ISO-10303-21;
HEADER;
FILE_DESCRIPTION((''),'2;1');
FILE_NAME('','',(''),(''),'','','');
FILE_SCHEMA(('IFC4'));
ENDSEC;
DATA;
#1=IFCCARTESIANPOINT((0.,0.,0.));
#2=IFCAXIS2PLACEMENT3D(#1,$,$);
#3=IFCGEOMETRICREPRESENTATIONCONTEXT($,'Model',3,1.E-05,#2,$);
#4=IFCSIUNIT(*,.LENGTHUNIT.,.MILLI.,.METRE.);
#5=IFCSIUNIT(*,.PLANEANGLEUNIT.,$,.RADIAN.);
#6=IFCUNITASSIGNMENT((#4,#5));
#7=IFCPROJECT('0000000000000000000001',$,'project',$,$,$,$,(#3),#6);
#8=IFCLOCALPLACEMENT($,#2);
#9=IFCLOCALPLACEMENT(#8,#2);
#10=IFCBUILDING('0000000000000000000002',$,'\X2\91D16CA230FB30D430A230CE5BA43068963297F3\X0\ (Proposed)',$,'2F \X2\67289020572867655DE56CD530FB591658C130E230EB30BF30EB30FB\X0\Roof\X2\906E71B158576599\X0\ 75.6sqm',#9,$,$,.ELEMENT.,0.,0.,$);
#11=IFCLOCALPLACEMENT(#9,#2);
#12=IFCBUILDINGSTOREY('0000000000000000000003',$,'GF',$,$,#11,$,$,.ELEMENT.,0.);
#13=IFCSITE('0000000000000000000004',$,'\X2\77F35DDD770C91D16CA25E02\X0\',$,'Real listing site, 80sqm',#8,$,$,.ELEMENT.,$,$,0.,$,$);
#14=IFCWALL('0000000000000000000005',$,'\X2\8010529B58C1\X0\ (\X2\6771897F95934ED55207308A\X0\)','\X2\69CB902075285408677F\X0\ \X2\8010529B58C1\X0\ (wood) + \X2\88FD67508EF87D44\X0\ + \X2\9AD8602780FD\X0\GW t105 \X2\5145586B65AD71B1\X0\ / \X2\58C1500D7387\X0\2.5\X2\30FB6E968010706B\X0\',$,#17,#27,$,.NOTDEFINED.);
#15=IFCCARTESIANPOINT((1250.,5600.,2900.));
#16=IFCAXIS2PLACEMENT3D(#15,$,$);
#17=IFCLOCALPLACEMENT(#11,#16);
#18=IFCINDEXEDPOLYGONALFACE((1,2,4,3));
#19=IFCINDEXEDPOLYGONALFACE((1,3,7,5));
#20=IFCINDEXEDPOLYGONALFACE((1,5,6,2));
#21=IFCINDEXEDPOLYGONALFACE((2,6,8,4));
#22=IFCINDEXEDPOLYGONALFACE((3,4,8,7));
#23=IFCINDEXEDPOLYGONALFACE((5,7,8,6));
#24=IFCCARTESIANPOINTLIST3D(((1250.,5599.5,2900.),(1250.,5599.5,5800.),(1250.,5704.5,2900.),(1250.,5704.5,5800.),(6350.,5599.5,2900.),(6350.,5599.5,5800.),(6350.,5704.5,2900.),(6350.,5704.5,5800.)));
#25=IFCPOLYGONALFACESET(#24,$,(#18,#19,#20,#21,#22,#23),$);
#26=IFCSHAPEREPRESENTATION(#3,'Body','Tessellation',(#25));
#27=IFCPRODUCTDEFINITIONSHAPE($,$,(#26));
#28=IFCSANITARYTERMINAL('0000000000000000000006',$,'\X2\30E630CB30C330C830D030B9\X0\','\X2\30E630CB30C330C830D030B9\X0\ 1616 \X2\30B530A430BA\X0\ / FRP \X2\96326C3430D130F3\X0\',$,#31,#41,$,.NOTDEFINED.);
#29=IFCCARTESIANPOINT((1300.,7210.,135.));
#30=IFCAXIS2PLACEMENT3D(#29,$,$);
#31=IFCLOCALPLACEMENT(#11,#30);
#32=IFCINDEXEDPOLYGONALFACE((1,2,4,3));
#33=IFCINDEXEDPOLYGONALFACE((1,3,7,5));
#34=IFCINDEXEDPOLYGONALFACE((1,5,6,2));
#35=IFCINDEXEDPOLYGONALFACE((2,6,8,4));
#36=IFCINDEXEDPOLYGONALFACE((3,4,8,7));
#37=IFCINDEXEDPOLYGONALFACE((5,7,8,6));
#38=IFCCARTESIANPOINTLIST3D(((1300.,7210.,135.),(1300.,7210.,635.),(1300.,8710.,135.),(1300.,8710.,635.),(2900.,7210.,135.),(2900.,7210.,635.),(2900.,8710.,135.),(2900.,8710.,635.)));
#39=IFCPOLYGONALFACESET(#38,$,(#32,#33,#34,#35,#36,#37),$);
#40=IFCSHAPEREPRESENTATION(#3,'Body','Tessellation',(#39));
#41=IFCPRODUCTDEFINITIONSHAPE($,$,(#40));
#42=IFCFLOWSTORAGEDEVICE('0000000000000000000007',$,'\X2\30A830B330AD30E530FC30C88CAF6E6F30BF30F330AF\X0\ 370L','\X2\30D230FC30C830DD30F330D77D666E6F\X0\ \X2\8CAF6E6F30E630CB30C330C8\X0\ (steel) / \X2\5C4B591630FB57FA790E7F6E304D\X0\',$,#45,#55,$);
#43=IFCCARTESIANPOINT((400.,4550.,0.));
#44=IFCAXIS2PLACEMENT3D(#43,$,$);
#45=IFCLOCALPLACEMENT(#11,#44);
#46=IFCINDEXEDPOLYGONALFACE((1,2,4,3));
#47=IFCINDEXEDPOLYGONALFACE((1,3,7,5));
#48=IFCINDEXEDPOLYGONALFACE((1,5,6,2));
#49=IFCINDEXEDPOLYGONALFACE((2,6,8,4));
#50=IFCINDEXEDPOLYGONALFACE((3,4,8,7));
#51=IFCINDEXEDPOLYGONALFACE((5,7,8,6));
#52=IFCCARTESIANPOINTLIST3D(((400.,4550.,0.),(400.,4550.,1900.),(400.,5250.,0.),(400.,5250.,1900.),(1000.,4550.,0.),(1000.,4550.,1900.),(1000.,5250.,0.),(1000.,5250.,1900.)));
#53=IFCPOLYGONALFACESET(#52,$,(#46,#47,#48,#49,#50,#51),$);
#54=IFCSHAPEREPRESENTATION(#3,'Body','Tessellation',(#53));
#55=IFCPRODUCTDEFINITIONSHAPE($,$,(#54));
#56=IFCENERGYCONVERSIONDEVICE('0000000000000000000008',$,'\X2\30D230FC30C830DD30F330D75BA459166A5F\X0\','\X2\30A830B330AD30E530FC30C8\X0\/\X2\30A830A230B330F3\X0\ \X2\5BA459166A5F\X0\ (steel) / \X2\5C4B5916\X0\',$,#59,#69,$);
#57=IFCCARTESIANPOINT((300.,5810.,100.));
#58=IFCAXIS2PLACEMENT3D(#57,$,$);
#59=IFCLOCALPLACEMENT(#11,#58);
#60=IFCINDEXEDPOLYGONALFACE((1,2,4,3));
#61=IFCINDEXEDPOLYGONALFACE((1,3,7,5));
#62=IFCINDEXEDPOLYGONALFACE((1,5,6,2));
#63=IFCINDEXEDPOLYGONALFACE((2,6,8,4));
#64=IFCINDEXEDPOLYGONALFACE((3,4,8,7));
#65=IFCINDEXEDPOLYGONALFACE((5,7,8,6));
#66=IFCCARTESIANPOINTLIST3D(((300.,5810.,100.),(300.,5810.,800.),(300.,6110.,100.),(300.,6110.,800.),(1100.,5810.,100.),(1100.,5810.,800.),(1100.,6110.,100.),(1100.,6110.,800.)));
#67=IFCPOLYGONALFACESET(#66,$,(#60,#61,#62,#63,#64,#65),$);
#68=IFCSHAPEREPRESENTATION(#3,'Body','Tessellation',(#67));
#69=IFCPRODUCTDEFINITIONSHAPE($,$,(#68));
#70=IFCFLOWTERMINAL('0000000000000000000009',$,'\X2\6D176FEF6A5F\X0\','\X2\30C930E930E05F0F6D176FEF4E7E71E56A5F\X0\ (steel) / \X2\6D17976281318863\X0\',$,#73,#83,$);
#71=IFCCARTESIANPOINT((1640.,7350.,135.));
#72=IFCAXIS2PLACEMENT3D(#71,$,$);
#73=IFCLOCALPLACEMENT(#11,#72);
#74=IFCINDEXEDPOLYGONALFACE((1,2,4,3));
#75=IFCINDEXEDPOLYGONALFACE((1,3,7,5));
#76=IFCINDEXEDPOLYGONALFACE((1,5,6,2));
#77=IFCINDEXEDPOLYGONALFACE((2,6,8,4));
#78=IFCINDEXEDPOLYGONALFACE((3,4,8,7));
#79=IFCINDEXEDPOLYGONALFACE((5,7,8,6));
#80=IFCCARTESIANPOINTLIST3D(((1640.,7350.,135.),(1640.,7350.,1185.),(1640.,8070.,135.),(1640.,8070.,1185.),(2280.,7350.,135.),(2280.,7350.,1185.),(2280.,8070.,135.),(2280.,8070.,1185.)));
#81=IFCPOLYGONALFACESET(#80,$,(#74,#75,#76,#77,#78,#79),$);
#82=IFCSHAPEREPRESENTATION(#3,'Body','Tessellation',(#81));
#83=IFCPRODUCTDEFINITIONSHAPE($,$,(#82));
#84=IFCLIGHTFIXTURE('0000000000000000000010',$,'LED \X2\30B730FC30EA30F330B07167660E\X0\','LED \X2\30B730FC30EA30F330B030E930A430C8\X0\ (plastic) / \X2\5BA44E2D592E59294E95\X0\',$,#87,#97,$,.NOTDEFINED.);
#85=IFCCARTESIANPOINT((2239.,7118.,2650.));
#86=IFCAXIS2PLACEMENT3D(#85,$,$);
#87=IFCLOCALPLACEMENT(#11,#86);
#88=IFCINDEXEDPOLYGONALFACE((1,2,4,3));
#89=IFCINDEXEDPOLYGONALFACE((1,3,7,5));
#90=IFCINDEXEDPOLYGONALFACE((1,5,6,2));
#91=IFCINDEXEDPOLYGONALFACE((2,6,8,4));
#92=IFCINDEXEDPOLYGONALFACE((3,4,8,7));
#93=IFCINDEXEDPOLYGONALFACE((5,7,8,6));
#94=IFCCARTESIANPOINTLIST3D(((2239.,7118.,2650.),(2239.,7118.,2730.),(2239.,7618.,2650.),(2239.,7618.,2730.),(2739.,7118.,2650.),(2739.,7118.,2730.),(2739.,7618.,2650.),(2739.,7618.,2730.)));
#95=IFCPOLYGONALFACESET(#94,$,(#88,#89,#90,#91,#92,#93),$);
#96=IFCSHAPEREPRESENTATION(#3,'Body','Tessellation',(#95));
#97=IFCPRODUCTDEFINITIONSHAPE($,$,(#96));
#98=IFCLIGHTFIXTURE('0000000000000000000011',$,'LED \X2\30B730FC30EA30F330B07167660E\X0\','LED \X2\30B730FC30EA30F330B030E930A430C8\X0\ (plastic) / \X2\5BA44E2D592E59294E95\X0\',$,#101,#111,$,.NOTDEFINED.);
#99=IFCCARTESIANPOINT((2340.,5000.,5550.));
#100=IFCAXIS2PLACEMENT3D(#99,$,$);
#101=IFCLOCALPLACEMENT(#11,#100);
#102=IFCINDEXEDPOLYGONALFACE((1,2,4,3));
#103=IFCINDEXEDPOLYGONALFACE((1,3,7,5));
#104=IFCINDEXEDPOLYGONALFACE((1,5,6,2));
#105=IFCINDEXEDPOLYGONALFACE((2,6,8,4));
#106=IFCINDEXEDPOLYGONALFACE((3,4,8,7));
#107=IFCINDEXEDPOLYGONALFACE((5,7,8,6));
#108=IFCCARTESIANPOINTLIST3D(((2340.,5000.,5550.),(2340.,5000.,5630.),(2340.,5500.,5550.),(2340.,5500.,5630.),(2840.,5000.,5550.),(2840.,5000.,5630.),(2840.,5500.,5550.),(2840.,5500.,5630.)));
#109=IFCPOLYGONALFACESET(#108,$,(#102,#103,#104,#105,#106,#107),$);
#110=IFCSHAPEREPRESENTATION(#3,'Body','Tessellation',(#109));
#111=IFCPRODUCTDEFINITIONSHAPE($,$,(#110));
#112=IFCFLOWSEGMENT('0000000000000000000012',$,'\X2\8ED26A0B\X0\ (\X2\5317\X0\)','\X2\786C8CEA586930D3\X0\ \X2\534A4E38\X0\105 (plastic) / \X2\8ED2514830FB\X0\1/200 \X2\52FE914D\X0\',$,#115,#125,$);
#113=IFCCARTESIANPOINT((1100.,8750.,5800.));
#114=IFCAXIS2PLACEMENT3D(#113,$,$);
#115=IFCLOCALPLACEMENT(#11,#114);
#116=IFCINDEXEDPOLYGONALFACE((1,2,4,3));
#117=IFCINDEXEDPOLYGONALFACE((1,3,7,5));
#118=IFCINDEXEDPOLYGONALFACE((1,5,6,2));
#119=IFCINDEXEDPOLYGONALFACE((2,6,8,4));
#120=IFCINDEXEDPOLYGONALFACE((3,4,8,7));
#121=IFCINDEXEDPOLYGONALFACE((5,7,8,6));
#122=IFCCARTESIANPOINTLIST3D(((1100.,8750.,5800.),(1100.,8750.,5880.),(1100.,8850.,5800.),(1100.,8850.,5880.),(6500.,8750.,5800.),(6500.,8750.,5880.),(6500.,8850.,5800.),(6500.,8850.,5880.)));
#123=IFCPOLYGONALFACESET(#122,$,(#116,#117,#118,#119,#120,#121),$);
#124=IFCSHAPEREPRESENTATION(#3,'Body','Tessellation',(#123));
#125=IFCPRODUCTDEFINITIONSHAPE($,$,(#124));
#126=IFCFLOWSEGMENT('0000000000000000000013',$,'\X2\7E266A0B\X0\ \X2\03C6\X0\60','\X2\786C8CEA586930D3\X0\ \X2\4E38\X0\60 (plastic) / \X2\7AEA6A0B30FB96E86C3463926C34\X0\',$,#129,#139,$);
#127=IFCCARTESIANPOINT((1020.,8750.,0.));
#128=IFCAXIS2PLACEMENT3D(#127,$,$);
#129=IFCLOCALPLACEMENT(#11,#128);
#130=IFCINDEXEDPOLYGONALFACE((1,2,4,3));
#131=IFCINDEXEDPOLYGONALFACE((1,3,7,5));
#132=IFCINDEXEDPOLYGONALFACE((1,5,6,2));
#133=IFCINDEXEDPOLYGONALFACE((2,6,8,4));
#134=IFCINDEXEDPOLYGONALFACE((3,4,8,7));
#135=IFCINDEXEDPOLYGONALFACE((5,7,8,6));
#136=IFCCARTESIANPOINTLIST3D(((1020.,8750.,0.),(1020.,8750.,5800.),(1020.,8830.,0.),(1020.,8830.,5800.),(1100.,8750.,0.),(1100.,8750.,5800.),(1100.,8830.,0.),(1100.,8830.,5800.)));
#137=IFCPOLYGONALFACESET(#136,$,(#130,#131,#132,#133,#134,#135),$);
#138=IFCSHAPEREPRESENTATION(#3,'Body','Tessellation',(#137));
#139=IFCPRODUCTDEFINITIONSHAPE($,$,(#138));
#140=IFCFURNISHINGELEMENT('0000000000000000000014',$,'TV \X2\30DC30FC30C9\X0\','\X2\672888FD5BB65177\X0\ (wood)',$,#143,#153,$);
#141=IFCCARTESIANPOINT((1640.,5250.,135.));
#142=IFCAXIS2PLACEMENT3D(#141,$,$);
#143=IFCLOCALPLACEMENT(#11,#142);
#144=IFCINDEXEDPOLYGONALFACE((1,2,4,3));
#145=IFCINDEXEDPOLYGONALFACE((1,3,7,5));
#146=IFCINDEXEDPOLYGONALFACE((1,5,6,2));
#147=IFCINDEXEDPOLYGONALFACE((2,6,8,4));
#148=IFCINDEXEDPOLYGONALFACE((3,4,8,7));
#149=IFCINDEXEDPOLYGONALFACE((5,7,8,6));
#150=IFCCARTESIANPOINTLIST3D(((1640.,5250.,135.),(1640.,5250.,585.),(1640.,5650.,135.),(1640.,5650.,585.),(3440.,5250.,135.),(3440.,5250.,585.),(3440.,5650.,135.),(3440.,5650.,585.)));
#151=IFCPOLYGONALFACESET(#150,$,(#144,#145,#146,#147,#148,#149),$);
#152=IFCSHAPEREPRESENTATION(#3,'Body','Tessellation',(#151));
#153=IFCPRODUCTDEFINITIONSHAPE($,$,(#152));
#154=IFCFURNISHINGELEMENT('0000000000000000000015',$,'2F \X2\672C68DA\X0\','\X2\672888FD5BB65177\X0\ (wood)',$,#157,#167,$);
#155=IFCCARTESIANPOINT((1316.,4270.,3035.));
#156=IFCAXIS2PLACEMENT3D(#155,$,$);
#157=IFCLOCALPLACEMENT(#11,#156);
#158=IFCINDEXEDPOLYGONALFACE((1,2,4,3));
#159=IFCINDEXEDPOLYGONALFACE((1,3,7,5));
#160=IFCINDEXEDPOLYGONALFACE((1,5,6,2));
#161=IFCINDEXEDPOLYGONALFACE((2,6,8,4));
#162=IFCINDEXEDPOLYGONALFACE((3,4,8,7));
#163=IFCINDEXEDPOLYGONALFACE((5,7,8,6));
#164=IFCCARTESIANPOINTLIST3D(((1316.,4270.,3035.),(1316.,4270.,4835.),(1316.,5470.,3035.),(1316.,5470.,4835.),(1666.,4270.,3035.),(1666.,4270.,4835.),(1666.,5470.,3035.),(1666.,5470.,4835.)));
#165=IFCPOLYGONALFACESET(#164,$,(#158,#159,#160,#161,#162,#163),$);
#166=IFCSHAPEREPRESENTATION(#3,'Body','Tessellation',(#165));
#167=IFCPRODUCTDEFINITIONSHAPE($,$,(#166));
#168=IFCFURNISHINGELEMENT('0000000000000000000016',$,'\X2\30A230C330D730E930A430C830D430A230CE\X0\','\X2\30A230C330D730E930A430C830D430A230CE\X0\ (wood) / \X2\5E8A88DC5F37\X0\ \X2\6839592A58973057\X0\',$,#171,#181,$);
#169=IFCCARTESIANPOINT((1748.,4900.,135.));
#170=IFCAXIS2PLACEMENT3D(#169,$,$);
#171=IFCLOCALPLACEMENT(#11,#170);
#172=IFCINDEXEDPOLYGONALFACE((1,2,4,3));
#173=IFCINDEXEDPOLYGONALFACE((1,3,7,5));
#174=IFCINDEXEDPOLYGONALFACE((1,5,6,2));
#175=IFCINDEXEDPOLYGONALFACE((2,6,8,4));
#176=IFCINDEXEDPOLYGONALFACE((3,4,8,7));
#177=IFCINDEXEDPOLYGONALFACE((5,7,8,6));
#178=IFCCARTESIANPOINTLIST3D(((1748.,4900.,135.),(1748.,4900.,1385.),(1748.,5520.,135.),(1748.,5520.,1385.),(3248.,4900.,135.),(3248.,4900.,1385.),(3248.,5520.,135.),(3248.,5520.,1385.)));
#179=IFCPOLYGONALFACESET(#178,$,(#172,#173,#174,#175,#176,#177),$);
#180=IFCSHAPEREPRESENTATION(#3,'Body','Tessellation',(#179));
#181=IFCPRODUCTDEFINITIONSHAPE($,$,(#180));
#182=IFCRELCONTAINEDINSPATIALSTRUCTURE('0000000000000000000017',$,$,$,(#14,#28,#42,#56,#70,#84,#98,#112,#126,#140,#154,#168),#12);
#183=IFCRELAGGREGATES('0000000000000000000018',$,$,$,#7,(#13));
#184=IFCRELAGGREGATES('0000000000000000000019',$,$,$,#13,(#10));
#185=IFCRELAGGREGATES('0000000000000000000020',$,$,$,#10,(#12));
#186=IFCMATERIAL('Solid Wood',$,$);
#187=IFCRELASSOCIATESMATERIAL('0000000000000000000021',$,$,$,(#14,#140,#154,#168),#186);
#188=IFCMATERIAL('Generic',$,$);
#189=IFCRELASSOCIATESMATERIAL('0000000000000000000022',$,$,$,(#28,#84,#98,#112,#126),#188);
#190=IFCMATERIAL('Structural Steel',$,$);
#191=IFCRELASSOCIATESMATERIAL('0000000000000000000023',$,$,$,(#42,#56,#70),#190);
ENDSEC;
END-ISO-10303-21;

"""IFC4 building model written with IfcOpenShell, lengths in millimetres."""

from ifc_helpers import new_model, si_unit, frame, frame_2d, origin, place, context, project, spatial, rectangle, extrude, material, element, save


model = new_model("IFC4")

# Units and contexts
model_context = context("Model", 3, precision=1e-05, world=origin())
ifc_project = project(units=[si_unit("LENGTHUNIT", "METRE", prefix="MILLI"), si_unit("PLANEANGLEUNIT", "RADIAN")], contexts=[model_context])

# Site, building, storey
site_placement = place(None, origin())
site = spatial("IfcSite", under=ifc_project, at=site_placement, Name="石川県金沢市", ObjectType="Real listing site, 80sqm", CompositionType="ELEMENT", RefElevation=0.0)
building_placement = place(site_placement, origin())
building = spatial("IfcBuilding", under=site, at=building_placement, Name="金沢・ピアノ室と防音 (Proposed)", ObjectType="2F 木造在来工法・外壁モルタル・Roof遮熱塗料 75.6sqm", CompositionType="ELEMENT", ElevationOfRefHeight=0.0, ElevationOfTerrain=0.0)
storey_placement = place(building_placement, origin())
storey = spatial("IfcBuildingStorey", under=building, at=storey_placement, Name="GF", CompositionType="ELEMENT", Elevation=0.0)

# Shared definitions
ifc_material_1 = material(Name="Solid Wood")

# Wall
wall_1_placement = place(storey_placement, frame((1250.0, 5600.0, 2900.0)))
element("IfcWall", 1, at=wall_1_placement, inside=storey, material=ifc_material_1, Name="耐力壁 (東西間仕切り)", Description="構造用合板 耐力壁 (wood) + 製材軸組 + 高性能GW t105 充填断熱 / 壁倍率2.5・準耐火", PredefinedType="NOTDEFINED", context=model_context, shape_type="SweptSolid", body=[
    extrude(rectangle(XDim=5100.0, YDim=105.0, at=frame_2d((2550.0, 52.0))), frame((1250.0, 5600.0, 2900.0)), (0.0, 0.0, 1.0), 2900.0),
])

# Sanitary terminal
ifc_material_2 = material(Name="Generic")
sanitary_terminal_placement = place(storey_placement, frame((1300.0, 7210.0, 135.0)))
element("IfcSanitaryTerminal", 2, at=sanitary_terminal_placement, inside=storey, material=ifc_material_2, Name="ユニットバス", Description="ユニットバス 1616 サイズ / FRP 防水パン", PredefinedType="NOTDEFINED", context=model_context, shape_type="SweptSolid", body=[
    extrude(rectangle(XDim=1600.0, YDim=1500.0, at=frame_2d((800.0, 750.0))), frame((1300.0, 7210.0, 135.0)), (0.0, 0.0, 1.0), 500.0),
])

# Flow storage device
ifc_material_3 = material(Name="Structural Steel")
flow_storage_device_placement = place(storey_placement, frame((400.0, 4550.0, 0.0)))
element("IfcFlowStorageDevice", 3, at=flow_storage_device_placement, inside=storey, material=ifc_material_3, Name="エコキュート貯湯タンク 370L", Description="ヒートポンプ給湯 貯湯ユニット (steel) / 屋外・基礎置き", context=model_context, shape_type="SweptSolid", body=[
    extrude(rectangle(XDim=600.0, YDim=700.0, at=frame_2d((300.0, 350.0))), frame((400.0, 4550.0, 0.0)), (0.0, 0.0, 1.0), 1900.0),
])

# Energy conversion device
energy_conversion_device_placement = place(storey_placement, frame((300.0, 5810.0, 100.0)))
element("IfcEnergyConversionDevice", 4, at=energy_conversion_device_placement, inside=storey, material=ifc_material_3, Name="ヒートポンプ室外機", Description="エコキュート/エアコン 室外機 (steel) / 屋外", context=model_context, shape_type="SweptSolid", body=[
    extrude(rectangle(XDim=800.0, YDim=300.0, at=frame_2d((400.0, 150.0))), frame((300.0, 5810.0, 100.0)), (0.0, 0.0, 1.0), 700.0),
])

# Flow terminal
flow_terminal_placement = place(storey_placement, frame((1640.0, 7350.0, 135.0)))
element("IfcFlowTerminal", 5, at=flow_terminal_placement, inside=storey, material=ifc_material_3, Name="洗濯機", Description="ドラム式洗濯乾燥機 (steel) / 洗面脱衣", context=model_context, shape_type="SweptSolid", body=[
    extrude(rectangle(XDim=640.0, YDim=720.0, at=frame_2d((320.0, 360.0))), frame((1640.0, 7350.0, 135.0)), (0.0, 0.0, 1.0), 1050.0),
])

# Light fixtures
light_fixture_1_placement = place(storey_placement, frame((2239.0, 7118.0, 2650.0)))
element("IfcLightFixture", 6, at=light_fixture_1_placement, inside=storey, material=ifc_material_2, Name="LED シーリング照明", Description="LED シーリングライト (plastic) / 室中央天井", PredefinedType="NOTDEFINED", context=model_context, shape_type="SweptSolid", body=[
    extrude(rectangle(XDim=500.0, YDim=500.0, at=frame_2d((250.0, 250.0))), frame((2239.0, 7118.0, 2650.0)), (0.0, 0.0, 1.0), 80.0),
])
light_fixture_2_placement = place(storey_placement, frame((2340.0, 5000.0, 5550.0)))
element("IfcLightFixture", 7, at=light_fixture_2_placement, inside=storey, material=ifc_material_2, Name="LED シーリング照明", Description="LED シーリングライト (plastic) / 室中央天井", PredefinedType="NOTDEFINED", context=model_context, shape_type="SweptSolid", body=[
    extrude(rectangle(XDim=500.0, YDim=500.0, at=frame_2d((250.0, 250.0))), frame((2340.0, 5000.0, 5550.0)), (0.0, 0.0, 1.0), 80.0),
])

# Flow segments
flow_segment_1_placement = place(storey_placement, frame((1100.0, 8750.0, 5800.0)))
element("IfcFlowSegment", 8, at=flow_segment_1_placement, inside=storey, material=ifc_material_2, Name="軒樋 (北)", Description="硬質塩ビ 半丸105 (plastic) / 軒先・1/200 勾配", context=model_context, shape_type="SweptSolid", body=[
    extrude(rectangle(XDim=5400.0, YDim=100.0, at=frame_2d((2700.0, 50.0))), frame((1100.0, 8750.0, 5800.0)), (0.0, 0.0, 1.0), 80.0),
])
flow_segment_2_placement = place(storey_placement, frame((1020.0, 8750.0, 0.0)))
element("IfcFlowSegment", 9, at=flow_segment_2_placement, inside=storey, material=ifc_material_2, Name="縦樋 φ60", Description="硬質塩ビ 丸60 (plastic) / 竪樋・雨水排水", context=model_context, shape_type="SweptSolid", body=[
    extrude(rectangle(XDim=80.0, YDim=80.0, at=frame_2d((40.0, 40.0))), frame((1020.0, 8750.0, 0.0)), (0.0, 0.0, 1.0), 5800.0),
])

# Furnishing elements
furnishing_1_placement = place(storey_placement, frame((1640.0, 5250.0, 135.0)))
element("IfcFurnishingElement", 10, at=furnishing_1_placement, inside=storey, material=ifc_material_1, Name="TV ボード", Description="木製家具 (wood)", context=model_context, shape_type="SweptSolid", body=[
    extrude(rectangle(XDim=1800.0, YDim=400.0, at=frame_2d((900.0, 200.0))), frame((1640.0, 5250.0, 135.0)), (0.0, 0.0, 1.0), 450.0),
])
furnishing_2_placement = place(storey_placement, frame((1316.0, 4270.0, 3035.0)))
element("IfcFurnishingElement", 11, at=furnishing_2_placement, inside=storey, material=ifc_material_1, Name="2F 本棚", Description="木製家具 (wood)", context=model_context, shape_type="SweptSolid", body=[
    extrude(rectangle(XDim=350.0, YDim=1200.0, at=frame_2d((175.0, 600.0))), frame((1316.0, 4270.0, 3035.0)), (0.0, 0.0, 1.0), 1800.0),
])
furnishing_3_placement = place(storey_placement, frame((1748.0, 4900.0, 135.0)))
element("IfcFurnishingElement", 12, at=furnishing_3_placement, inside=storey, material=ifc_material_1, Name="アップライトピアノ", Description="アップライトピアノ (wood) / 床補強 根太増し", context=model_context, shape_type="SweptSolid", body=[
    extrude(rectangle(XDim=1500.0, YDim=620.0, at=frame_2d((750.0, 310.0))), frame((1748.0, 4900.0, 135.0)), (0.0, 0.0, 1.0), 1250.0),
])

save(model, "model.ifc")
